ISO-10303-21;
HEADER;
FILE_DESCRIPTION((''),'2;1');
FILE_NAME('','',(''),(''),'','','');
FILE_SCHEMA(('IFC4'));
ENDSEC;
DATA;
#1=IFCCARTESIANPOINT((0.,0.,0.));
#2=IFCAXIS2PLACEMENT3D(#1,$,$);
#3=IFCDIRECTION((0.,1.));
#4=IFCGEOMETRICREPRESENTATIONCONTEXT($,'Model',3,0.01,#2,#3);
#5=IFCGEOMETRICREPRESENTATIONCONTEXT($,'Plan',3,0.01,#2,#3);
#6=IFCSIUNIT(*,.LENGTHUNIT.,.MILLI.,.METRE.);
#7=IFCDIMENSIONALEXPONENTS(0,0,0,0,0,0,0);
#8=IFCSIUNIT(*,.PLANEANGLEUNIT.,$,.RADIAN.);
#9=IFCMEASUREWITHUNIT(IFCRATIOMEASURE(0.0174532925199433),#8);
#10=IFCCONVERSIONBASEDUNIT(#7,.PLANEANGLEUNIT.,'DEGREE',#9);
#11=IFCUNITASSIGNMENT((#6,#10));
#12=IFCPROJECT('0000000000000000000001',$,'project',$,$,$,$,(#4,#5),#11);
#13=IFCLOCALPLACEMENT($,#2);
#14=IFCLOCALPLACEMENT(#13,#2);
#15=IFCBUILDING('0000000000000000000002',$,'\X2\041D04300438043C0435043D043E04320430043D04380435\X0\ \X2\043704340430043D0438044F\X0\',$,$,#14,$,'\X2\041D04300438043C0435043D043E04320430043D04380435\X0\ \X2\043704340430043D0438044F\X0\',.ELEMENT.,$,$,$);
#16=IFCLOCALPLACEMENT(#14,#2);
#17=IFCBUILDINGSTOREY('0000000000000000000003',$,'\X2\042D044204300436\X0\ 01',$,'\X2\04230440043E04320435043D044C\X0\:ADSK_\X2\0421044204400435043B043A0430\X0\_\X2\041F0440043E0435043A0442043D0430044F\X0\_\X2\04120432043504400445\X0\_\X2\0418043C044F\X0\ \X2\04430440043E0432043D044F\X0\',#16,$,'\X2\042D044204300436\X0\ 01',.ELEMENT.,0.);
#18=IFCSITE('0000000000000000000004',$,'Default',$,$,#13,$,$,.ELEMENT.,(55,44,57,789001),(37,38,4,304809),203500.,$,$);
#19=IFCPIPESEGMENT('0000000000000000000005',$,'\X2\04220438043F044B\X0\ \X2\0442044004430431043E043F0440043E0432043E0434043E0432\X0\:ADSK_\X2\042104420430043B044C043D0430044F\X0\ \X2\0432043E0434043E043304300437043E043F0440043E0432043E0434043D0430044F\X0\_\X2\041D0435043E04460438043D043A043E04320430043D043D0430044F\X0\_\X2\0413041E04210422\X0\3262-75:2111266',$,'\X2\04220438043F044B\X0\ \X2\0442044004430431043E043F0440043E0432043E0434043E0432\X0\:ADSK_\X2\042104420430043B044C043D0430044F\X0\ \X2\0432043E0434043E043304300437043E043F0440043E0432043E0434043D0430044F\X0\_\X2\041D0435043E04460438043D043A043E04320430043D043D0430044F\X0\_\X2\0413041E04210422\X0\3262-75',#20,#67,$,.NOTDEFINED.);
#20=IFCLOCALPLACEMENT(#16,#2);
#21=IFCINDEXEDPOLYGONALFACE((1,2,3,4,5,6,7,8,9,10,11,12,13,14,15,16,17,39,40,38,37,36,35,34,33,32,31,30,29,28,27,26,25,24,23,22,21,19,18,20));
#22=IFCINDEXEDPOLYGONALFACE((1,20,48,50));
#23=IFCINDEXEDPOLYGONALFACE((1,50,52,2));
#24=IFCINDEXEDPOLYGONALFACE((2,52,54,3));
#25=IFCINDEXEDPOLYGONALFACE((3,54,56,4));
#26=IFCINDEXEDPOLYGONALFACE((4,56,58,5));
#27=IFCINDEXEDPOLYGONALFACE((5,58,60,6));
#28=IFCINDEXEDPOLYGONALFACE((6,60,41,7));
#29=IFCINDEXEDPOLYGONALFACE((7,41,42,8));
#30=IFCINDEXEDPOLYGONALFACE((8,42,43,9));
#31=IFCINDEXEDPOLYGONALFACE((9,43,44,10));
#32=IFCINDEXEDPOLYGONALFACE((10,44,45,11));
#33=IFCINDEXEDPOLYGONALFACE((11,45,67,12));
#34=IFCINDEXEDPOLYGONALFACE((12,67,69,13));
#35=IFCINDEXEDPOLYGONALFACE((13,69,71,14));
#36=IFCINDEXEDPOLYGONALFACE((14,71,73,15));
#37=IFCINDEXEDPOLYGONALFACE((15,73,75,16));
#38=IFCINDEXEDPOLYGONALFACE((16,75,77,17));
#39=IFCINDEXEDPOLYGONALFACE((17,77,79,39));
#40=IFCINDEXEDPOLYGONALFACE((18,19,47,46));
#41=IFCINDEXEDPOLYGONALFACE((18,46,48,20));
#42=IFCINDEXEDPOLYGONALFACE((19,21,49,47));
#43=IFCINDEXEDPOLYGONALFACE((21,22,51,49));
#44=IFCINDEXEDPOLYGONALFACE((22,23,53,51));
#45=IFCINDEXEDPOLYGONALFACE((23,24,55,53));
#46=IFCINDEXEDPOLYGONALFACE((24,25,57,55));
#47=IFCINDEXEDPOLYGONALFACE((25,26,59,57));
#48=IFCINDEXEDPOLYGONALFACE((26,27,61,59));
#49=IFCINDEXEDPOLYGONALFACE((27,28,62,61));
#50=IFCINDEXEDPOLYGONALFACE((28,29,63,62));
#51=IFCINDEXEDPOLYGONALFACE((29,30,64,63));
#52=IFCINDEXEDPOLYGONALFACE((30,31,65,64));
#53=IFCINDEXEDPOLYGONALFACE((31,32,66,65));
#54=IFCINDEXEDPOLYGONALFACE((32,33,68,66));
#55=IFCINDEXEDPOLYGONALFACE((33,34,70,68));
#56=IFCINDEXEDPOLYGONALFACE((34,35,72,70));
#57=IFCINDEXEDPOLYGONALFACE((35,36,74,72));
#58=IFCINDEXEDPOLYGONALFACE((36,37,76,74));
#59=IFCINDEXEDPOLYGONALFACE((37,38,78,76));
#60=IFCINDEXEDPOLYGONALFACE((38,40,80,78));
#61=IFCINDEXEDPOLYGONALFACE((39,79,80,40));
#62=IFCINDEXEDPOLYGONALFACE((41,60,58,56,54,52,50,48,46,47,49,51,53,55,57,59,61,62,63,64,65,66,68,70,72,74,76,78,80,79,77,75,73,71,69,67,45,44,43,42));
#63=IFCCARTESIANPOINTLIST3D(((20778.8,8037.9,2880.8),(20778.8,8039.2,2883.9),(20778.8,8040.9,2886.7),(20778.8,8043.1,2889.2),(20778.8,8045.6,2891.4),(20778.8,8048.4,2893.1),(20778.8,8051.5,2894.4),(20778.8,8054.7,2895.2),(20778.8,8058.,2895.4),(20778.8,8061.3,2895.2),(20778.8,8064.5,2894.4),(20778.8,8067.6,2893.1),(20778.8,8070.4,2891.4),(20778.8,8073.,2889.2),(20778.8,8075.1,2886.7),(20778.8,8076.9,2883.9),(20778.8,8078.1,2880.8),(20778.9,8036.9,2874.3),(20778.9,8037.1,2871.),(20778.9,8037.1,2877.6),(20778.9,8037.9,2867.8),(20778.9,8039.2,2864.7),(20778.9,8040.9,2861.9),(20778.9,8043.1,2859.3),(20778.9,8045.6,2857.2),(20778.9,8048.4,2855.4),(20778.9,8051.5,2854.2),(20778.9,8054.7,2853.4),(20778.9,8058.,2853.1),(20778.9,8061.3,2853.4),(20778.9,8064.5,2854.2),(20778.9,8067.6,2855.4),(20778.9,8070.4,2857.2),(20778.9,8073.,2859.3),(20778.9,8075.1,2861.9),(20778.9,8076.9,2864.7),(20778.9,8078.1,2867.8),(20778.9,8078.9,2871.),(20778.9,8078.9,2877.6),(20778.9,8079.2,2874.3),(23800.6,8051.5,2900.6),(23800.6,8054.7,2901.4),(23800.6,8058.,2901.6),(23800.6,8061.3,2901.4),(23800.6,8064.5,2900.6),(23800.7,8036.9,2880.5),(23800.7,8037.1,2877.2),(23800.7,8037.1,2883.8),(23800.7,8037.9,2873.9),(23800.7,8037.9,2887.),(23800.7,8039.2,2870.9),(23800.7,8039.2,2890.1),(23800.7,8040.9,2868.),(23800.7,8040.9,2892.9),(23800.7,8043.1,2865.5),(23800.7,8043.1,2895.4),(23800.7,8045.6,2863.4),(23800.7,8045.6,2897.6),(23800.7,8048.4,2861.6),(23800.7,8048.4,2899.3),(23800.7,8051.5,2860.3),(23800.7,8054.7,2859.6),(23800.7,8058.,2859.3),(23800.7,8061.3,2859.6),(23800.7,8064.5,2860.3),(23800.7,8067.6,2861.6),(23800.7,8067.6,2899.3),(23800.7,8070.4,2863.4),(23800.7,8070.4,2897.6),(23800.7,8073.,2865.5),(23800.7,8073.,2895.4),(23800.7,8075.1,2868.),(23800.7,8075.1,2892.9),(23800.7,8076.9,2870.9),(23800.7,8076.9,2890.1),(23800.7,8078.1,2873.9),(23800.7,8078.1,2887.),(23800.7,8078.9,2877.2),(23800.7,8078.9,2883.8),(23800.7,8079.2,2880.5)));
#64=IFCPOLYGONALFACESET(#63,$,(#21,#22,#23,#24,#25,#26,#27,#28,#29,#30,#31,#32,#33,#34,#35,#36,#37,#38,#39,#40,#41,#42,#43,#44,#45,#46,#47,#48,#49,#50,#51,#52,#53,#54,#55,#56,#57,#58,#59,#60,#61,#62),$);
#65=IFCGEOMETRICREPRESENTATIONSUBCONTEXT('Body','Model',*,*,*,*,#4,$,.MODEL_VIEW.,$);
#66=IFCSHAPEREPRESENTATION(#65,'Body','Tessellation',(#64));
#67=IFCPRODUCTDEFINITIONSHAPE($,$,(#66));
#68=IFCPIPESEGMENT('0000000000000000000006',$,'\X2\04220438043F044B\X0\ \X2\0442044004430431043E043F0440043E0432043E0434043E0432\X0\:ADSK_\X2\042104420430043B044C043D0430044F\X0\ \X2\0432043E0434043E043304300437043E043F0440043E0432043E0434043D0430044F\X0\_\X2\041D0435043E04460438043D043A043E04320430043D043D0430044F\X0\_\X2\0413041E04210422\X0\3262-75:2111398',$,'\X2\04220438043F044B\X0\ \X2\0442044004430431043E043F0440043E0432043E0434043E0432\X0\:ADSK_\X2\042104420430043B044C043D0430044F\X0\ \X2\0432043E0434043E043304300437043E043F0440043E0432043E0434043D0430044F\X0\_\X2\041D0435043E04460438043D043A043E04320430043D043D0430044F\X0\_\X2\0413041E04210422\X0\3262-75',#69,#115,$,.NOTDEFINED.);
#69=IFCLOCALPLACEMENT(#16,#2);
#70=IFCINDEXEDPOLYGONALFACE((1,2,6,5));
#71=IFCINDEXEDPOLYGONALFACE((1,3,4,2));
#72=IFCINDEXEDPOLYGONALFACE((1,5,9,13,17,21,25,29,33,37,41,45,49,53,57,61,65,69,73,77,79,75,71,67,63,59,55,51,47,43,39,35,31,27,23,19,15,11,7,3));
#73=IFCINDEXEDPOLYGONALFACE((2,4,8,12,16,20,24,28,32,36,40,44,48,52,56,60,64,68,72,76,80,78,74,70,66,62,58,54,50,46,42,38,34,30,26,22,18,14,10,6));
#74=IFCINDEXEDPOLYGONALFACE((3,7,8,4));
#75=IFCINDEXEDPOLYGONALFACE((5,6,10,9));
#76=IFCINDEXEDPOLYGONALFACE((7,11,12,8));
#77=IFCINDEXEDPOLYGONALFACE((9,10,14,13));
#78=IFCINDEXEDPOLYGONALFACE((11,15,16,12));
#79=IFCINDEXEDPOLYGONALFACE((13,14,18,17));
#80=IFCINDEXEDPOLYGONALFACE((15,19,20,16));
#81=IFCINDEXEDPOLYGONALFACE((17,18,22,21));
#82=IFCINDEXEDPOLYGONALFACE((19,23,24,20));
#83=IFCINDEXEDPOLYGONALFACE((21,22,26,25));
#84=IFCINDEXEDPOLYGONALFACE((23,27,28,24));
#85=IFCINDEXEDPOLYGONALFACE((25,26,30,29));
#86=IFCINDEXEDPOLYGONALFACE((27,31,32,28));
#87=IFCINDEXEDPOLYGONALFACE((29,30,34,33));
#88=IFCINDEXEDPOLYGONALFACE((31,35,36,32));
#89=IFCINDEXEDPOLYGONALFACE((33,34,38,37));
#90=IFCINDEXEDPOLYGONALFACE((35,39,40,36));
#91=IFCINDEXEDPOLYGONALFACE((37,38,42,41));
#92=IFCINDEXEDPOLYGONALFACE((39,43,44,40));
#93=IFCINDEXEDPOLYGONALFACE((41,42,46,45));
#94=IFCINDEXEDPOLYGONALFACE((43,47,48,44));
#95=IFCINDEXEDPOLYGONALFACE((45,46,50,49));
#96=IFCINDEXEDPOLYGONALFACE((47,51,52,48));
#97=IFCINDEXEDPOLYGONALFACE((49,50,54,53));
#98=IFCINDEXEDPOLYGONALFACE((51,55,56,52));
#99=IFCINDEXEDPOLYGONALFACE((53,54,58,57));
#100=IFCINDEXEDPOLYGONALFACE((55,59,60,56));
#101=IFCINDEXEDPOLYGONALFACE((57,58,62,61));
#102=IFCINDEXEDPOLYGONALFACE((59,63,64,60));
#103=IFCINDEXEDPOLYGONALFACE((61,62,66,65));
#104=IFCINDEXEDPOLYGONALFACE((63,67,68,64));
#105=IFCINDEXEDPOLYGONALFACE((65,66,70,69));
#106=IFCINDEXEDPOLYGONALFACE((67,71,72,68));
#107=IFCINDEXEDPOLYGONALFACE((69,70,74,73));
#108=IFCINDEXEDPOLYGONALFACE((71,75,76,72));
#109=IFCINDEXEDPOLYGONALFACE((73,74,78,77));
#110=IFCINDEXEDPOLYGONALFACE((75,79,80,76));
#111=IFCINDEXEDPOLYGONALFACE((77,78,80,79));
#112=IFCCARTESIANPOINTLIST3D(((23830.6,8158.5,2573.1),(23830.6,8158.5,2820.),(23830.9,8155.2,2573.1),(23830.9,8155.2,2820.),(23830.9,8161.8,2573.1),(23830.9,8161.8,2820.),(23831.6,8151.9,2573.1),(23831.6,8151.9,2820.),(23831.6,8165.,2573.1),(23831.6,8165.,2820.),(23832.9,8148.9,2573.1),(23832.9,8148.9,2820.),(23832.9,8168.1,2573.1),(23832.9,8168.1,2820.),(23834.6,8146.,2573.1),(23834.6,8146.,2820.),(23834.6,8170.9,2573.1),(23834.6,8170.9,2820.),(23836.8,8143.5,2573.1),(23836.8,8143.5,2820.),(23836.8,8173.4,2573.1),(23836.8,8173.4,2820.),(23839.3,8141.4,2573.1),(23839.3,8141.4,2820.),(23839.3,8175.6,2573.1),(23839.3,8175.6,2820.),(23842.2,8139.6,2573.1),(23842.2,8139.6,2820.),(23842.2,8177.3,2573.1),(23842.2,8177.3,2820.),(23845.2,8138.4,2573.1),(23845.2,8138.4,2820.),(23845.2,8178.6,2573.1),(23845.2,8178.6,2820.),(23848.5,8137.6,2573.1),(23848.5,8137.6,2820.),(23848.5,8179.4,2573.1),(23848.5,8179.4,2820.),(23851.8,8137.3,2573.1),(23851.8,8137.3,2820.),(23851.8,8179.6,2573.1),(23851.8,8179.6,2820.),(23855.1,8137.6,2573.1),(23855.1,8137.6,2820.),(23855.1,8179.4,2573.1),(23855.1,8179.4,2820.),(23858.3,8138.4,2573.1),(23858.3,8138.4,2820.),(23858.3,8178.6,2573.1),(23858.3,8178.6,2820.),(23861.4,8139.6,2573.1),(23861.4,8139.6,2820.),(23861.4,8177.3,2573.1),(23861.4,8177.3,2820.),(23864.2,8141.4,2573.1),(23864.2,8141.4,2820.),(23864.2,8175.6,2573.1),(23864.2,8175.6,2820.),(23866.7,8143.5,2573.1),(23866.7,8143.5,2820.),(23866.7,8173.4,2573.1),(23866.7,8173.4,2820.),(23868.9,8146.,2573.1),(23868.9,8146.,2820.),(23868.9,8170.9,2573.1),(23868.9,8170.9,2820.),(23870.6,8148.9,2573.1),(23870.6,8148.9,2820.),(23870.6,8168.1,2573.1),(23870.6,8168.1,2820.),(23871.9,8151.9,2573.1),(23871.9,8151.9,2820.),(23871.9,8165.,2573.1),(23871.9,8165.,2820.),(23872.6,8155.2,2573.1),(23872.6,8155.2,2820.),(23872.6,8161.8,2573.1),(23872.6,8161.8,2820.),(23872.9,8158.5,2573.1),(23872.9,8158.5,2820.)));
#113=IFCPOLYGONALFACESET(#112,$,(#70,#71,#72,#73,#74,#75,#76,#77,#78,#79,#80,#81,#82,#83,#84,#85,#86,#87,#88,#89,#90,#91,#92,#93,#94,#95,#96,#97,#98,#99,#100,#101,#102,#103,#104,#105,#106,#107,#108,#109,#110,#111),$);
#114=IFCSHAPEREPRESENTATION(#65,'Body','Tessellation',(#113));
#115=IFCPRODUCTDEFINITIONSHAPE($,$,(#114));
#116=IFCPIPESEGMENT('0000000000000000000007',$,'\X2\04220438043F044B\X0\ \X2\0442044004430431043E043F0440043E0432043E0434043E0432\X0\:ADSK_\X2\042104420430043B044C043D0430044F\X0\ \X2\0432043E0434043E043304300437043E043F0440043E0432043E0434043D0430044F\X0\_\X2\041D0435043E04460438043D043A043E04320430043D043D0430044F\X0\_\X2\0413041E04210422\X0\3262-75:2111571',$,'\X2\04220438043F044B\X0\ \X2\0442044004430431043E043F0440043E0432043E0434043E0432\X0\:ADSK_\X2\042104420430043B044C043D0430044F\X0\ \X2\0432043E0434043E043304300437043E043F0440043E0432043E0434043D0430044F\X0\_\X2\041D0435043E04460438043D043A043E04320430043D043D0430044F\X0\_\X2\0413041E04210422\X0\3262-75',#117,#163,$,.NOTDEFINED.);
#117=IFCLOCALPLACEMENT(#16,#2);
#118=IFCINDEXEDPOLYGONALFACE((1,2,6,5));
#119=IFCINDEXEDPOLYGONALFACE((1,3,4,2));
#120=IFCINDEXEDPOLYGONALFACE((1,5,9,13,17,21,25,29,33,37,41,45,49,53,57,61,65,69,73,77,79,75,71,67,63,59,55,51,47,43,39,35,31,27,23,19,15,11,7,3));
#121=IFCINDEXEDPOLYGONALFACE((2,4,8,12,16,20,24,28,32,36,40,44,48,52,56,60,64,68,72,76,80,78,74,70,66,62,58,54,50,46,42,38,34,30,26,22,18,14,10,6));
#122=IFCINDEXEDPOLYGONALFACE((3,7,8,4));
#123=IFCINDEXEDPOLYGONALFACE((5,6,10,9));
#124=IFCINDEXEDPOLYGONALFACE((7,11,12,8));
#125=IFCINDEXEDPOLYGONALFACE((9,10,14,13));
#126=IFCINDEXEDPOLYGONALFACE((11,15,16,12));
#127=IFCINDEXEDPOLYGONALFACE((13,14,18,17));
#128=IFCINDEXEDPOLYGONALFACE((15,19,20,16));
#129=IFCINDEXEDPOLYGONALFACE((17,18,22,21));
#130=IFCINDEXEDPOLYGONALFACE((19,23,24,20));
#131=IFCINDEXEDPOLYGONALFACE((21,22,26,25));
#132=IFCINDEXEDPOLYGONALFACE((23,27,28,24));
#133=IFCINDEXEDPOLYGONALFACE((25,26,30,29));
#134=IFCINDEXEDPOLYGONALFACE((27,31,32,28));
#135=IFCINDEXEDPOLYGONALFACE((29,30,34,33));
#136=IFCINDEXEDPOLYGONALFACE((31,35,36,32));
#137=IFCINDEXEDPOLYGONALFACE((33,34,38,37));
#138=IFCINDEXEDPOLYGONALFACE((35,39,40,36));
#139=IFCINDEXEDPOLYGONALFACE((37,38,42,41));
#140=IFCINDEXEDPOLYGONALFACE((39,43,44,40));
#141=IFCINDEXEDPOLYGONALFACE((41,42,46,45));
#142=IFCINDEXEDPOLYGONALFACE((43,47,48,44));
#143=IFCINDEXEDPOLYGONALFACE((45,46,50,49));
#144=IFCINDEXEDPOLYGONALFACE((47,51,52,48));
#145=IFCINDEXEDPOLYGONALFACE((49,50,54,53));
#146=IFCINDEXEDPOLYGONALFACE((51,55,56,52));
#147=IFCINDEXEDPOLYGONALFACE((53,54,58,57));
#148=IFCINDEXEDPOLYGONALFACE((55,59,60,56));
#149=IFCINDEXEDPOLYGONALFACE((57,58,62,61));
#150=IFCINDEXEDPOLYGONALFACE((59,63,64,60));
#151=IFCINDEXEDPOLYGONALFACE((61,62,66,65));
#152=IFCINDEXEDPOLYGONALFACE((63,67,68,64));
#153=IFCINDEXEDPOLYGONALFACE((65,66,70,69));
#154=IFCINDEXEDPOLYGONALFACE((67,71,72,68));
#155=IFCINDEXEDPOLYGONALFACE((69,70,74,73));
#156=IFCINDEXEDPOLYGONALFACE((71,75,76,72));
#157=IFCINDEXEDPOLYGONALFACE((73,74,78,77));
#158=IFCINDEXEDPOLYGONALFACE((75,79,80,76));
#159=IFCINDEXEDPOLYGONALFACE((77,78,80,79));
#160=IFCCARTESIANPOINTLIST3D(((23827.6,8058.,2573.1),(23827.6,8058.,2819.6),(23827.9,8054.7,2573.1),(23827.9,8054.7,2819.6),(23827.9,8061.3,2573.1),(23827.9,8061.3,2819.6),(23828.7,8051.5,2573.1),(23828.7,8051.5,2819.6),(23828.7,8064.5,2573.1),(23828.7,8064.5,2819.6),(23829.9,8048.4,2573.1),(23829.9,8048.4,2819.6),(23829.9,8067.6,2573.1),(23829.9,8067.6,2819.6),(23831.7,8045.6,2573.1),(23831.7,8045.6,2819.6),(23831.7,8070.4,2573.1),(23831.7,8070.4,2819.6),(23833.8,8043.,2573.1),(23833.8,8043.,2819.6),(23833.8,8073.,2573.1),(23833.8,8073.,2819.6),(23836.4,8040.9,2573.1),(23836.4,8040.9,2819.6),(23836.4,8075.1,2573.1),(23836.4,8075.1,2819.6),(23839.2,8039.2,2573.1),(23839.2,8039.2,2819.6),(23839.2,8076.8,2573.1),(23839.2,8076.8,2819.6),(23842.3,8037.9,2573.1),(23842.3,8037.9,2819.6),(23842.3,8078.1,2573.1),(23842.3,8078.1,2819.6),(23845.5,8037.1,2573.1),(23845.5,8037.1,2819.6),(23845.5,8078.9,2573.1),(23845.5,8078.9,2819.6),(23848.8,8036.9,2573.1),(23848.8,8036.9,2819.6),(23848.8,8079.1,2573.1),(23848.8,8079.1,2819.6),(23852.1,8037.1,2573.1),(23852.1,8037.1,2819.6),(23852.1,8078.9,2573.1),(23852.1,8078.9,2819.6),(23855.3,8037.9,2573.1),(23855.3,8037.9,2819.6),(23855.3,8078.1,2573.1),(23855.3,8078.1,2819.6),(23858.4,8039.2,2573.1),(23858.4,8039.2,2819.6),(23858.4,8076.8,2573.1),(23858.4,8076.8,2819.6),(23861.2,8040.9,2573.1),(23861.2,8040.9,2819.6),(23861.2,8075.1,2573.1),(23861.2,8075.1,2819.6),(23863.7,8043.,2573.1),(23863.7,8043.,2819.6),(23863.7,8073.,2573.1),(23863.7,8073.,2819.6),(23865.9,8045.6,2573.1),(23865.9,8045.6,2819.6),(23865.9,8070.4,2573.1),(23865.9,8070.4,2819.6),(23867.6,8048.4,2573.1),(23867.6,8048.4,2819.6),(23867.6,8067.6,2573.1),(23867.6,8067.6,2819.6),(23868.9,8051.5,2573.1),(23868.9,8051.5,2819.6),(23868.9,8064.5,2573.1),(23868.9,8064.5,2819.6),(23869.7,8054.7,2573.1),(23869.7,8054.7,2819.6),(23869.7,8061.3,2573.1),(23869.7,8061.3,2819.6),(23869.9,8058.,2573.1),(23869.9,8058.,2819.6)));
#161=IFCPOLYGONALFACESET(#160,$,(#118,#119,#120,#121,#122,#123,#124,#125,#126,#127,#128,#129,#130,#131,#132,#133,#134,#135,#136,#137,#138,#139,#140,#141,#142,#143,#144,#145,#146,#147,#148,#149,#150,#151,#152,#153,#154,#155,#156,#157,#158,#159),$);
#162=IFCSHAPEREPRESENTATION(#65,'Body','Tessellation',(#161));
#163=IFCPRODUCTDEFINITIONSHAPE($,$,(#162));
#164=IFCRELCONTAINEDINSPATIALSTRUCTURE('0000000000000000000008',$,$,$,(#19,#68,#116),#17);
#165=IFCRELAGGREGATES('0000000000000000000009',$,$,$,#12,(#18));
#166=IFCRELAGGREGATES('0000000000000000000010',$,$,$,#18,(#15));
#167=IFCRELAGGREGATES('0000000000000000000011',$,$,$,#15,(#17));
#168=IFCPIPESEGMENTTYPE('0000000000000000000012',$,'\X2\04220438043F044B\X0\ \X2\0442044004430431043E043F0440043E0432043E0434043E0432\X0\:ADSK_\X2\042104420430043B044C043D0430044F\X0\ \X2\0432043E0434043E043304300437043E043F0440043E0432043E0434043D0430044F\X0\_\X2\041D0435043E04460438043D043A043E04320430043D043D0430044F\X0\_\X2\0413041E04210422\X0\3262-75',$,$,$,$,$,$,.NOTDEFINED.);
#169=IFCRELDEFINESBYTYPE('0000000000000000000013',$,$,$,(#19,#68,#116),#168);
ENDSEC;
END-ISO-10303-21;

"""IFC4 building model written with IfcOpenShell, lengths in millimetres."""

from ifc_helpers import new_model, entity, si_unit, converted_unit, direction, frame, origin, place, context, subcontext, project, spatial, indexed_curve, outline, extrude, type_object, element, save


model = new_model("IFC4")

# Units and contexts
model_context = context("Model", 3, precision=0.01, world=origin(), true_north=direction((0.0, 1.0)))
plan_context = context("Plan", 3, precision=0.01, world=origin(), true_north=direction((0.0, 1.0)))
body_context = subcontext(model_context, "Body", "Model", "MODEL_VIEW")
ifc_project = project(units=[si_unit("LENGTHUNIT", "METRE", prefix="MILLI"), converted_unit("PLANEANGLEUNIT", "DEGREE", entity("IfcRatioMeasure", 0.0174532925199433), si_unit("PLANEANGLEUNIT", "RADIAN"), dimensions=[0, 0, 0, 0, 0, 0, 0])], contexts=[model_context, plan_context])

# Site, building, storey
site_placement = place(None, origin())
site = spatial("IfcSite", under=ifc_project, at=site_placement, Name="Default", CompositionType="ELEMENT", RefLatitude=(55, 44, 57, 789001), RefLongitude=(37, 38, 4, 304809), RefElevation=203500.0)
building_placement = place(site_placement, origin())
building = spatial("IfcBuilding", under=site, at=building_placement, Name="Наименование здания", LongName="Наименование здания", CompositionType="ELEMENT")
storey_placement = place(building_placement, origin())
storey = spatial("IfcBuildingStorey", under=building, at=storey_placement, Name="Этаж 01", ObjectType="Уровень:ADSK_Стрелка_Проектная_Вверх_Имя уровня", LongName="Этаж 01", CompositionType="ELEMENT", Elevation=0.0)

# Pipe segments
pipe_segment_type = type_object("IfcPipeSegmentType", Name="Типы трубопроводов:ADSK_Стальная водогазопроводная_Неоцинкованная_ГОСТ3262-75", PredefinedType="NOTDEFINED")
placement = place(storey_placement, origin())
element("IfcPipeSegment", 1, at=placement, inside=storey, type_object=pipe_segment_type, Name="Типы трубопроводов:ADSK_Стальная водогазопроводная_Неоцинкованная_ГОСТ3262-75:2111266", ObjectType="Типы трубопроводов:ADSK_Стальная водогазопроводная_Неоцинкованная_ГОСТ3262-75", PredefinedType="NOTDEFINED", context=body_context, shape_type="SweptSolid", body=[
    extrude(outline(indexed_curve([(21.1, 0.0), (20.9, 3.3), (20.1, 6.5), (18.8, 9.6), (17.1, 12.4), (15.0, 15.0), (12.4, 17.1), (9.6, 18.8), (6.5, 20.1), (3.3, 20.9), (0.0, 21.2), (-3.3, 20.9), (-6.5, 20.1), (-9.6, 18.8), (-12.4, 17.1), (-15.0, 15.0), (-17.1, 12.4), (-18.8, 9.6), (-20.1, 6.5), (-20.9, 3.3), (-21.1, 0.0), (-20.9, -3.3), (-20.1, -6.5), (-18.8, -9.6), (-17.1, -12.4), (-15.0, -15.0), (-12.4, -17.1), (-9.6, -18.8), (-6.5, -20.1), (-3.3, -20.9), (0.0, -21.2), (3.3, -20.9), (6.5, -20.1), (9.6, -18.8), (12.4, -17.1), (15.0, -15.0), (17.1, -12.4), (18.8, -9.6), (20.1, -6.5), (20.9, -3.3), (21.1, 0.0)], self_intersect=False)), frame((20778.9, 8058.0, 2874.3), z_axis=(0.999998, 0.0, 0.002042), x_axis=(0.0, 1.0, 0.0)), (0.0, 0.0, 1.0), 3021.8),
])
element("IfcPipeSegment", 2, at=placement, inside=storey, type_object=pipe_segment_type, Name="Типы трубопроводов:ADSK_Стальная водогазопроводная_Неоцинкованная_ГОСТ3262-75:2111398", ObjectType="Типы трубопроводов:ADSK_Стальная водогазопроводная_Неоцинкованная_ГОСТ3262-75", PredefinedType="NOTDEFINED", context=body_context, shape_type="SweptSolid", body=[
    extrude(outline(indexed_curve([(21.2, 0.0), (20.9, 3.3), (20.1, 6.5), (18.8, 9.6), (17.1, 12.4), (15.0, 15.0), (12.4, 17.1), (9.6, 18.8), (6.5, 20.1), (3.3, 20.9), (0.0, 21.2), (-3.3, 20.9), (-6.5, 20.1), (-9.6, 18.8), (-12.4, 17.1), (-15.0, 15.0), (-17.1, 12.4), (-18.8, 9.6), (-20.1, 6.5), (-20.9, 3.3), (-21.2, 0.0), (-20.9, -3.3), (-20.1, -6.5), (-18.8, -9.6), (-17.1, -12.4), (-15.0, -15.0), (-12.4, -17.1), (-9.6, -18.8), (-6.5, -20.1), (-3.3, -20.9), (0.0, -21.1), (3.3, -20.9), (6.5, -20.1), (9.6, -18.8), (12.4, -17.1), (15.0, -15.0), (17.1, -12.4), (18.8, -9.6), (20.1, -6.5), (20.9, -3.3), (21.2, 0.0)], self_intersect=False)), frame((23851.8, 8158.5, 2573.1)), (0.0, 0.0, 1.0), 246.9),
])
element("IfcPipeSegment", 3, at=placement, inside=storey, type_object=pipe_segment_type, Name="Типы трубопроводов:ADSK_Стальная водогазопроводная_Неоцинкованная_ГОСТ3262-75:2111571", ObjectType="Типы трубопроводов:ADSK_Стальная водогазопроводная_Неоцинкованная_ГОСТ3262-75", PredefinedType="NOTDEFINED", context=body_context, shape_type="SweptSolid", body=[
    extrude(outline(indexed_curve([(21.1, 0.0), (20.9, 3.3), (20.1, 6.5), (18.8, 9.6), (17.1, 12.4), (15.0, 15.0), (12.4, 17.1), (9.6, 18.8), (6.5, 20.1), (3.3, 20.9), (0.0, 21.1), (-3.3, 20.9), (-6.5, 20.1), (-9.6, 18.8), (-12.4, 17.1), (-15.0, 15.0), (-17.1, 12.4), (-18.8, 9.6), (-20.1, 6.5), (-20.9, 3.3), (-21.1, 0.0), (-20.9, -3.3), (-20.1, -6.5), (-18.8, -9.6), (-17.1, -12.4), (-15.0, -15.0), (-12.4, -17.1), (-9.6, -18.8), (-6.5, -20.1), (-3.3, -20.9), (0.0, -21.1), (3.3, -20.9), (6.5, -20.1), (9.6, -18.8), (12.4, -17.1), (15.0, -15.0), (17.1, -12.4), (18.8, -9.6), (20.1, -6.5), (20.9, -3.3), (21.1, 0.0)], self_intersect=False)), frame((23848.8, 8058.0, 2573.1), z_axis=(0.0, 0.0, 1.0), x_axis=(-1.0, 0.0, 0.0)), (0.0, 0.0, 1.0), 246.5),
])

save(model, "model.ifc")
